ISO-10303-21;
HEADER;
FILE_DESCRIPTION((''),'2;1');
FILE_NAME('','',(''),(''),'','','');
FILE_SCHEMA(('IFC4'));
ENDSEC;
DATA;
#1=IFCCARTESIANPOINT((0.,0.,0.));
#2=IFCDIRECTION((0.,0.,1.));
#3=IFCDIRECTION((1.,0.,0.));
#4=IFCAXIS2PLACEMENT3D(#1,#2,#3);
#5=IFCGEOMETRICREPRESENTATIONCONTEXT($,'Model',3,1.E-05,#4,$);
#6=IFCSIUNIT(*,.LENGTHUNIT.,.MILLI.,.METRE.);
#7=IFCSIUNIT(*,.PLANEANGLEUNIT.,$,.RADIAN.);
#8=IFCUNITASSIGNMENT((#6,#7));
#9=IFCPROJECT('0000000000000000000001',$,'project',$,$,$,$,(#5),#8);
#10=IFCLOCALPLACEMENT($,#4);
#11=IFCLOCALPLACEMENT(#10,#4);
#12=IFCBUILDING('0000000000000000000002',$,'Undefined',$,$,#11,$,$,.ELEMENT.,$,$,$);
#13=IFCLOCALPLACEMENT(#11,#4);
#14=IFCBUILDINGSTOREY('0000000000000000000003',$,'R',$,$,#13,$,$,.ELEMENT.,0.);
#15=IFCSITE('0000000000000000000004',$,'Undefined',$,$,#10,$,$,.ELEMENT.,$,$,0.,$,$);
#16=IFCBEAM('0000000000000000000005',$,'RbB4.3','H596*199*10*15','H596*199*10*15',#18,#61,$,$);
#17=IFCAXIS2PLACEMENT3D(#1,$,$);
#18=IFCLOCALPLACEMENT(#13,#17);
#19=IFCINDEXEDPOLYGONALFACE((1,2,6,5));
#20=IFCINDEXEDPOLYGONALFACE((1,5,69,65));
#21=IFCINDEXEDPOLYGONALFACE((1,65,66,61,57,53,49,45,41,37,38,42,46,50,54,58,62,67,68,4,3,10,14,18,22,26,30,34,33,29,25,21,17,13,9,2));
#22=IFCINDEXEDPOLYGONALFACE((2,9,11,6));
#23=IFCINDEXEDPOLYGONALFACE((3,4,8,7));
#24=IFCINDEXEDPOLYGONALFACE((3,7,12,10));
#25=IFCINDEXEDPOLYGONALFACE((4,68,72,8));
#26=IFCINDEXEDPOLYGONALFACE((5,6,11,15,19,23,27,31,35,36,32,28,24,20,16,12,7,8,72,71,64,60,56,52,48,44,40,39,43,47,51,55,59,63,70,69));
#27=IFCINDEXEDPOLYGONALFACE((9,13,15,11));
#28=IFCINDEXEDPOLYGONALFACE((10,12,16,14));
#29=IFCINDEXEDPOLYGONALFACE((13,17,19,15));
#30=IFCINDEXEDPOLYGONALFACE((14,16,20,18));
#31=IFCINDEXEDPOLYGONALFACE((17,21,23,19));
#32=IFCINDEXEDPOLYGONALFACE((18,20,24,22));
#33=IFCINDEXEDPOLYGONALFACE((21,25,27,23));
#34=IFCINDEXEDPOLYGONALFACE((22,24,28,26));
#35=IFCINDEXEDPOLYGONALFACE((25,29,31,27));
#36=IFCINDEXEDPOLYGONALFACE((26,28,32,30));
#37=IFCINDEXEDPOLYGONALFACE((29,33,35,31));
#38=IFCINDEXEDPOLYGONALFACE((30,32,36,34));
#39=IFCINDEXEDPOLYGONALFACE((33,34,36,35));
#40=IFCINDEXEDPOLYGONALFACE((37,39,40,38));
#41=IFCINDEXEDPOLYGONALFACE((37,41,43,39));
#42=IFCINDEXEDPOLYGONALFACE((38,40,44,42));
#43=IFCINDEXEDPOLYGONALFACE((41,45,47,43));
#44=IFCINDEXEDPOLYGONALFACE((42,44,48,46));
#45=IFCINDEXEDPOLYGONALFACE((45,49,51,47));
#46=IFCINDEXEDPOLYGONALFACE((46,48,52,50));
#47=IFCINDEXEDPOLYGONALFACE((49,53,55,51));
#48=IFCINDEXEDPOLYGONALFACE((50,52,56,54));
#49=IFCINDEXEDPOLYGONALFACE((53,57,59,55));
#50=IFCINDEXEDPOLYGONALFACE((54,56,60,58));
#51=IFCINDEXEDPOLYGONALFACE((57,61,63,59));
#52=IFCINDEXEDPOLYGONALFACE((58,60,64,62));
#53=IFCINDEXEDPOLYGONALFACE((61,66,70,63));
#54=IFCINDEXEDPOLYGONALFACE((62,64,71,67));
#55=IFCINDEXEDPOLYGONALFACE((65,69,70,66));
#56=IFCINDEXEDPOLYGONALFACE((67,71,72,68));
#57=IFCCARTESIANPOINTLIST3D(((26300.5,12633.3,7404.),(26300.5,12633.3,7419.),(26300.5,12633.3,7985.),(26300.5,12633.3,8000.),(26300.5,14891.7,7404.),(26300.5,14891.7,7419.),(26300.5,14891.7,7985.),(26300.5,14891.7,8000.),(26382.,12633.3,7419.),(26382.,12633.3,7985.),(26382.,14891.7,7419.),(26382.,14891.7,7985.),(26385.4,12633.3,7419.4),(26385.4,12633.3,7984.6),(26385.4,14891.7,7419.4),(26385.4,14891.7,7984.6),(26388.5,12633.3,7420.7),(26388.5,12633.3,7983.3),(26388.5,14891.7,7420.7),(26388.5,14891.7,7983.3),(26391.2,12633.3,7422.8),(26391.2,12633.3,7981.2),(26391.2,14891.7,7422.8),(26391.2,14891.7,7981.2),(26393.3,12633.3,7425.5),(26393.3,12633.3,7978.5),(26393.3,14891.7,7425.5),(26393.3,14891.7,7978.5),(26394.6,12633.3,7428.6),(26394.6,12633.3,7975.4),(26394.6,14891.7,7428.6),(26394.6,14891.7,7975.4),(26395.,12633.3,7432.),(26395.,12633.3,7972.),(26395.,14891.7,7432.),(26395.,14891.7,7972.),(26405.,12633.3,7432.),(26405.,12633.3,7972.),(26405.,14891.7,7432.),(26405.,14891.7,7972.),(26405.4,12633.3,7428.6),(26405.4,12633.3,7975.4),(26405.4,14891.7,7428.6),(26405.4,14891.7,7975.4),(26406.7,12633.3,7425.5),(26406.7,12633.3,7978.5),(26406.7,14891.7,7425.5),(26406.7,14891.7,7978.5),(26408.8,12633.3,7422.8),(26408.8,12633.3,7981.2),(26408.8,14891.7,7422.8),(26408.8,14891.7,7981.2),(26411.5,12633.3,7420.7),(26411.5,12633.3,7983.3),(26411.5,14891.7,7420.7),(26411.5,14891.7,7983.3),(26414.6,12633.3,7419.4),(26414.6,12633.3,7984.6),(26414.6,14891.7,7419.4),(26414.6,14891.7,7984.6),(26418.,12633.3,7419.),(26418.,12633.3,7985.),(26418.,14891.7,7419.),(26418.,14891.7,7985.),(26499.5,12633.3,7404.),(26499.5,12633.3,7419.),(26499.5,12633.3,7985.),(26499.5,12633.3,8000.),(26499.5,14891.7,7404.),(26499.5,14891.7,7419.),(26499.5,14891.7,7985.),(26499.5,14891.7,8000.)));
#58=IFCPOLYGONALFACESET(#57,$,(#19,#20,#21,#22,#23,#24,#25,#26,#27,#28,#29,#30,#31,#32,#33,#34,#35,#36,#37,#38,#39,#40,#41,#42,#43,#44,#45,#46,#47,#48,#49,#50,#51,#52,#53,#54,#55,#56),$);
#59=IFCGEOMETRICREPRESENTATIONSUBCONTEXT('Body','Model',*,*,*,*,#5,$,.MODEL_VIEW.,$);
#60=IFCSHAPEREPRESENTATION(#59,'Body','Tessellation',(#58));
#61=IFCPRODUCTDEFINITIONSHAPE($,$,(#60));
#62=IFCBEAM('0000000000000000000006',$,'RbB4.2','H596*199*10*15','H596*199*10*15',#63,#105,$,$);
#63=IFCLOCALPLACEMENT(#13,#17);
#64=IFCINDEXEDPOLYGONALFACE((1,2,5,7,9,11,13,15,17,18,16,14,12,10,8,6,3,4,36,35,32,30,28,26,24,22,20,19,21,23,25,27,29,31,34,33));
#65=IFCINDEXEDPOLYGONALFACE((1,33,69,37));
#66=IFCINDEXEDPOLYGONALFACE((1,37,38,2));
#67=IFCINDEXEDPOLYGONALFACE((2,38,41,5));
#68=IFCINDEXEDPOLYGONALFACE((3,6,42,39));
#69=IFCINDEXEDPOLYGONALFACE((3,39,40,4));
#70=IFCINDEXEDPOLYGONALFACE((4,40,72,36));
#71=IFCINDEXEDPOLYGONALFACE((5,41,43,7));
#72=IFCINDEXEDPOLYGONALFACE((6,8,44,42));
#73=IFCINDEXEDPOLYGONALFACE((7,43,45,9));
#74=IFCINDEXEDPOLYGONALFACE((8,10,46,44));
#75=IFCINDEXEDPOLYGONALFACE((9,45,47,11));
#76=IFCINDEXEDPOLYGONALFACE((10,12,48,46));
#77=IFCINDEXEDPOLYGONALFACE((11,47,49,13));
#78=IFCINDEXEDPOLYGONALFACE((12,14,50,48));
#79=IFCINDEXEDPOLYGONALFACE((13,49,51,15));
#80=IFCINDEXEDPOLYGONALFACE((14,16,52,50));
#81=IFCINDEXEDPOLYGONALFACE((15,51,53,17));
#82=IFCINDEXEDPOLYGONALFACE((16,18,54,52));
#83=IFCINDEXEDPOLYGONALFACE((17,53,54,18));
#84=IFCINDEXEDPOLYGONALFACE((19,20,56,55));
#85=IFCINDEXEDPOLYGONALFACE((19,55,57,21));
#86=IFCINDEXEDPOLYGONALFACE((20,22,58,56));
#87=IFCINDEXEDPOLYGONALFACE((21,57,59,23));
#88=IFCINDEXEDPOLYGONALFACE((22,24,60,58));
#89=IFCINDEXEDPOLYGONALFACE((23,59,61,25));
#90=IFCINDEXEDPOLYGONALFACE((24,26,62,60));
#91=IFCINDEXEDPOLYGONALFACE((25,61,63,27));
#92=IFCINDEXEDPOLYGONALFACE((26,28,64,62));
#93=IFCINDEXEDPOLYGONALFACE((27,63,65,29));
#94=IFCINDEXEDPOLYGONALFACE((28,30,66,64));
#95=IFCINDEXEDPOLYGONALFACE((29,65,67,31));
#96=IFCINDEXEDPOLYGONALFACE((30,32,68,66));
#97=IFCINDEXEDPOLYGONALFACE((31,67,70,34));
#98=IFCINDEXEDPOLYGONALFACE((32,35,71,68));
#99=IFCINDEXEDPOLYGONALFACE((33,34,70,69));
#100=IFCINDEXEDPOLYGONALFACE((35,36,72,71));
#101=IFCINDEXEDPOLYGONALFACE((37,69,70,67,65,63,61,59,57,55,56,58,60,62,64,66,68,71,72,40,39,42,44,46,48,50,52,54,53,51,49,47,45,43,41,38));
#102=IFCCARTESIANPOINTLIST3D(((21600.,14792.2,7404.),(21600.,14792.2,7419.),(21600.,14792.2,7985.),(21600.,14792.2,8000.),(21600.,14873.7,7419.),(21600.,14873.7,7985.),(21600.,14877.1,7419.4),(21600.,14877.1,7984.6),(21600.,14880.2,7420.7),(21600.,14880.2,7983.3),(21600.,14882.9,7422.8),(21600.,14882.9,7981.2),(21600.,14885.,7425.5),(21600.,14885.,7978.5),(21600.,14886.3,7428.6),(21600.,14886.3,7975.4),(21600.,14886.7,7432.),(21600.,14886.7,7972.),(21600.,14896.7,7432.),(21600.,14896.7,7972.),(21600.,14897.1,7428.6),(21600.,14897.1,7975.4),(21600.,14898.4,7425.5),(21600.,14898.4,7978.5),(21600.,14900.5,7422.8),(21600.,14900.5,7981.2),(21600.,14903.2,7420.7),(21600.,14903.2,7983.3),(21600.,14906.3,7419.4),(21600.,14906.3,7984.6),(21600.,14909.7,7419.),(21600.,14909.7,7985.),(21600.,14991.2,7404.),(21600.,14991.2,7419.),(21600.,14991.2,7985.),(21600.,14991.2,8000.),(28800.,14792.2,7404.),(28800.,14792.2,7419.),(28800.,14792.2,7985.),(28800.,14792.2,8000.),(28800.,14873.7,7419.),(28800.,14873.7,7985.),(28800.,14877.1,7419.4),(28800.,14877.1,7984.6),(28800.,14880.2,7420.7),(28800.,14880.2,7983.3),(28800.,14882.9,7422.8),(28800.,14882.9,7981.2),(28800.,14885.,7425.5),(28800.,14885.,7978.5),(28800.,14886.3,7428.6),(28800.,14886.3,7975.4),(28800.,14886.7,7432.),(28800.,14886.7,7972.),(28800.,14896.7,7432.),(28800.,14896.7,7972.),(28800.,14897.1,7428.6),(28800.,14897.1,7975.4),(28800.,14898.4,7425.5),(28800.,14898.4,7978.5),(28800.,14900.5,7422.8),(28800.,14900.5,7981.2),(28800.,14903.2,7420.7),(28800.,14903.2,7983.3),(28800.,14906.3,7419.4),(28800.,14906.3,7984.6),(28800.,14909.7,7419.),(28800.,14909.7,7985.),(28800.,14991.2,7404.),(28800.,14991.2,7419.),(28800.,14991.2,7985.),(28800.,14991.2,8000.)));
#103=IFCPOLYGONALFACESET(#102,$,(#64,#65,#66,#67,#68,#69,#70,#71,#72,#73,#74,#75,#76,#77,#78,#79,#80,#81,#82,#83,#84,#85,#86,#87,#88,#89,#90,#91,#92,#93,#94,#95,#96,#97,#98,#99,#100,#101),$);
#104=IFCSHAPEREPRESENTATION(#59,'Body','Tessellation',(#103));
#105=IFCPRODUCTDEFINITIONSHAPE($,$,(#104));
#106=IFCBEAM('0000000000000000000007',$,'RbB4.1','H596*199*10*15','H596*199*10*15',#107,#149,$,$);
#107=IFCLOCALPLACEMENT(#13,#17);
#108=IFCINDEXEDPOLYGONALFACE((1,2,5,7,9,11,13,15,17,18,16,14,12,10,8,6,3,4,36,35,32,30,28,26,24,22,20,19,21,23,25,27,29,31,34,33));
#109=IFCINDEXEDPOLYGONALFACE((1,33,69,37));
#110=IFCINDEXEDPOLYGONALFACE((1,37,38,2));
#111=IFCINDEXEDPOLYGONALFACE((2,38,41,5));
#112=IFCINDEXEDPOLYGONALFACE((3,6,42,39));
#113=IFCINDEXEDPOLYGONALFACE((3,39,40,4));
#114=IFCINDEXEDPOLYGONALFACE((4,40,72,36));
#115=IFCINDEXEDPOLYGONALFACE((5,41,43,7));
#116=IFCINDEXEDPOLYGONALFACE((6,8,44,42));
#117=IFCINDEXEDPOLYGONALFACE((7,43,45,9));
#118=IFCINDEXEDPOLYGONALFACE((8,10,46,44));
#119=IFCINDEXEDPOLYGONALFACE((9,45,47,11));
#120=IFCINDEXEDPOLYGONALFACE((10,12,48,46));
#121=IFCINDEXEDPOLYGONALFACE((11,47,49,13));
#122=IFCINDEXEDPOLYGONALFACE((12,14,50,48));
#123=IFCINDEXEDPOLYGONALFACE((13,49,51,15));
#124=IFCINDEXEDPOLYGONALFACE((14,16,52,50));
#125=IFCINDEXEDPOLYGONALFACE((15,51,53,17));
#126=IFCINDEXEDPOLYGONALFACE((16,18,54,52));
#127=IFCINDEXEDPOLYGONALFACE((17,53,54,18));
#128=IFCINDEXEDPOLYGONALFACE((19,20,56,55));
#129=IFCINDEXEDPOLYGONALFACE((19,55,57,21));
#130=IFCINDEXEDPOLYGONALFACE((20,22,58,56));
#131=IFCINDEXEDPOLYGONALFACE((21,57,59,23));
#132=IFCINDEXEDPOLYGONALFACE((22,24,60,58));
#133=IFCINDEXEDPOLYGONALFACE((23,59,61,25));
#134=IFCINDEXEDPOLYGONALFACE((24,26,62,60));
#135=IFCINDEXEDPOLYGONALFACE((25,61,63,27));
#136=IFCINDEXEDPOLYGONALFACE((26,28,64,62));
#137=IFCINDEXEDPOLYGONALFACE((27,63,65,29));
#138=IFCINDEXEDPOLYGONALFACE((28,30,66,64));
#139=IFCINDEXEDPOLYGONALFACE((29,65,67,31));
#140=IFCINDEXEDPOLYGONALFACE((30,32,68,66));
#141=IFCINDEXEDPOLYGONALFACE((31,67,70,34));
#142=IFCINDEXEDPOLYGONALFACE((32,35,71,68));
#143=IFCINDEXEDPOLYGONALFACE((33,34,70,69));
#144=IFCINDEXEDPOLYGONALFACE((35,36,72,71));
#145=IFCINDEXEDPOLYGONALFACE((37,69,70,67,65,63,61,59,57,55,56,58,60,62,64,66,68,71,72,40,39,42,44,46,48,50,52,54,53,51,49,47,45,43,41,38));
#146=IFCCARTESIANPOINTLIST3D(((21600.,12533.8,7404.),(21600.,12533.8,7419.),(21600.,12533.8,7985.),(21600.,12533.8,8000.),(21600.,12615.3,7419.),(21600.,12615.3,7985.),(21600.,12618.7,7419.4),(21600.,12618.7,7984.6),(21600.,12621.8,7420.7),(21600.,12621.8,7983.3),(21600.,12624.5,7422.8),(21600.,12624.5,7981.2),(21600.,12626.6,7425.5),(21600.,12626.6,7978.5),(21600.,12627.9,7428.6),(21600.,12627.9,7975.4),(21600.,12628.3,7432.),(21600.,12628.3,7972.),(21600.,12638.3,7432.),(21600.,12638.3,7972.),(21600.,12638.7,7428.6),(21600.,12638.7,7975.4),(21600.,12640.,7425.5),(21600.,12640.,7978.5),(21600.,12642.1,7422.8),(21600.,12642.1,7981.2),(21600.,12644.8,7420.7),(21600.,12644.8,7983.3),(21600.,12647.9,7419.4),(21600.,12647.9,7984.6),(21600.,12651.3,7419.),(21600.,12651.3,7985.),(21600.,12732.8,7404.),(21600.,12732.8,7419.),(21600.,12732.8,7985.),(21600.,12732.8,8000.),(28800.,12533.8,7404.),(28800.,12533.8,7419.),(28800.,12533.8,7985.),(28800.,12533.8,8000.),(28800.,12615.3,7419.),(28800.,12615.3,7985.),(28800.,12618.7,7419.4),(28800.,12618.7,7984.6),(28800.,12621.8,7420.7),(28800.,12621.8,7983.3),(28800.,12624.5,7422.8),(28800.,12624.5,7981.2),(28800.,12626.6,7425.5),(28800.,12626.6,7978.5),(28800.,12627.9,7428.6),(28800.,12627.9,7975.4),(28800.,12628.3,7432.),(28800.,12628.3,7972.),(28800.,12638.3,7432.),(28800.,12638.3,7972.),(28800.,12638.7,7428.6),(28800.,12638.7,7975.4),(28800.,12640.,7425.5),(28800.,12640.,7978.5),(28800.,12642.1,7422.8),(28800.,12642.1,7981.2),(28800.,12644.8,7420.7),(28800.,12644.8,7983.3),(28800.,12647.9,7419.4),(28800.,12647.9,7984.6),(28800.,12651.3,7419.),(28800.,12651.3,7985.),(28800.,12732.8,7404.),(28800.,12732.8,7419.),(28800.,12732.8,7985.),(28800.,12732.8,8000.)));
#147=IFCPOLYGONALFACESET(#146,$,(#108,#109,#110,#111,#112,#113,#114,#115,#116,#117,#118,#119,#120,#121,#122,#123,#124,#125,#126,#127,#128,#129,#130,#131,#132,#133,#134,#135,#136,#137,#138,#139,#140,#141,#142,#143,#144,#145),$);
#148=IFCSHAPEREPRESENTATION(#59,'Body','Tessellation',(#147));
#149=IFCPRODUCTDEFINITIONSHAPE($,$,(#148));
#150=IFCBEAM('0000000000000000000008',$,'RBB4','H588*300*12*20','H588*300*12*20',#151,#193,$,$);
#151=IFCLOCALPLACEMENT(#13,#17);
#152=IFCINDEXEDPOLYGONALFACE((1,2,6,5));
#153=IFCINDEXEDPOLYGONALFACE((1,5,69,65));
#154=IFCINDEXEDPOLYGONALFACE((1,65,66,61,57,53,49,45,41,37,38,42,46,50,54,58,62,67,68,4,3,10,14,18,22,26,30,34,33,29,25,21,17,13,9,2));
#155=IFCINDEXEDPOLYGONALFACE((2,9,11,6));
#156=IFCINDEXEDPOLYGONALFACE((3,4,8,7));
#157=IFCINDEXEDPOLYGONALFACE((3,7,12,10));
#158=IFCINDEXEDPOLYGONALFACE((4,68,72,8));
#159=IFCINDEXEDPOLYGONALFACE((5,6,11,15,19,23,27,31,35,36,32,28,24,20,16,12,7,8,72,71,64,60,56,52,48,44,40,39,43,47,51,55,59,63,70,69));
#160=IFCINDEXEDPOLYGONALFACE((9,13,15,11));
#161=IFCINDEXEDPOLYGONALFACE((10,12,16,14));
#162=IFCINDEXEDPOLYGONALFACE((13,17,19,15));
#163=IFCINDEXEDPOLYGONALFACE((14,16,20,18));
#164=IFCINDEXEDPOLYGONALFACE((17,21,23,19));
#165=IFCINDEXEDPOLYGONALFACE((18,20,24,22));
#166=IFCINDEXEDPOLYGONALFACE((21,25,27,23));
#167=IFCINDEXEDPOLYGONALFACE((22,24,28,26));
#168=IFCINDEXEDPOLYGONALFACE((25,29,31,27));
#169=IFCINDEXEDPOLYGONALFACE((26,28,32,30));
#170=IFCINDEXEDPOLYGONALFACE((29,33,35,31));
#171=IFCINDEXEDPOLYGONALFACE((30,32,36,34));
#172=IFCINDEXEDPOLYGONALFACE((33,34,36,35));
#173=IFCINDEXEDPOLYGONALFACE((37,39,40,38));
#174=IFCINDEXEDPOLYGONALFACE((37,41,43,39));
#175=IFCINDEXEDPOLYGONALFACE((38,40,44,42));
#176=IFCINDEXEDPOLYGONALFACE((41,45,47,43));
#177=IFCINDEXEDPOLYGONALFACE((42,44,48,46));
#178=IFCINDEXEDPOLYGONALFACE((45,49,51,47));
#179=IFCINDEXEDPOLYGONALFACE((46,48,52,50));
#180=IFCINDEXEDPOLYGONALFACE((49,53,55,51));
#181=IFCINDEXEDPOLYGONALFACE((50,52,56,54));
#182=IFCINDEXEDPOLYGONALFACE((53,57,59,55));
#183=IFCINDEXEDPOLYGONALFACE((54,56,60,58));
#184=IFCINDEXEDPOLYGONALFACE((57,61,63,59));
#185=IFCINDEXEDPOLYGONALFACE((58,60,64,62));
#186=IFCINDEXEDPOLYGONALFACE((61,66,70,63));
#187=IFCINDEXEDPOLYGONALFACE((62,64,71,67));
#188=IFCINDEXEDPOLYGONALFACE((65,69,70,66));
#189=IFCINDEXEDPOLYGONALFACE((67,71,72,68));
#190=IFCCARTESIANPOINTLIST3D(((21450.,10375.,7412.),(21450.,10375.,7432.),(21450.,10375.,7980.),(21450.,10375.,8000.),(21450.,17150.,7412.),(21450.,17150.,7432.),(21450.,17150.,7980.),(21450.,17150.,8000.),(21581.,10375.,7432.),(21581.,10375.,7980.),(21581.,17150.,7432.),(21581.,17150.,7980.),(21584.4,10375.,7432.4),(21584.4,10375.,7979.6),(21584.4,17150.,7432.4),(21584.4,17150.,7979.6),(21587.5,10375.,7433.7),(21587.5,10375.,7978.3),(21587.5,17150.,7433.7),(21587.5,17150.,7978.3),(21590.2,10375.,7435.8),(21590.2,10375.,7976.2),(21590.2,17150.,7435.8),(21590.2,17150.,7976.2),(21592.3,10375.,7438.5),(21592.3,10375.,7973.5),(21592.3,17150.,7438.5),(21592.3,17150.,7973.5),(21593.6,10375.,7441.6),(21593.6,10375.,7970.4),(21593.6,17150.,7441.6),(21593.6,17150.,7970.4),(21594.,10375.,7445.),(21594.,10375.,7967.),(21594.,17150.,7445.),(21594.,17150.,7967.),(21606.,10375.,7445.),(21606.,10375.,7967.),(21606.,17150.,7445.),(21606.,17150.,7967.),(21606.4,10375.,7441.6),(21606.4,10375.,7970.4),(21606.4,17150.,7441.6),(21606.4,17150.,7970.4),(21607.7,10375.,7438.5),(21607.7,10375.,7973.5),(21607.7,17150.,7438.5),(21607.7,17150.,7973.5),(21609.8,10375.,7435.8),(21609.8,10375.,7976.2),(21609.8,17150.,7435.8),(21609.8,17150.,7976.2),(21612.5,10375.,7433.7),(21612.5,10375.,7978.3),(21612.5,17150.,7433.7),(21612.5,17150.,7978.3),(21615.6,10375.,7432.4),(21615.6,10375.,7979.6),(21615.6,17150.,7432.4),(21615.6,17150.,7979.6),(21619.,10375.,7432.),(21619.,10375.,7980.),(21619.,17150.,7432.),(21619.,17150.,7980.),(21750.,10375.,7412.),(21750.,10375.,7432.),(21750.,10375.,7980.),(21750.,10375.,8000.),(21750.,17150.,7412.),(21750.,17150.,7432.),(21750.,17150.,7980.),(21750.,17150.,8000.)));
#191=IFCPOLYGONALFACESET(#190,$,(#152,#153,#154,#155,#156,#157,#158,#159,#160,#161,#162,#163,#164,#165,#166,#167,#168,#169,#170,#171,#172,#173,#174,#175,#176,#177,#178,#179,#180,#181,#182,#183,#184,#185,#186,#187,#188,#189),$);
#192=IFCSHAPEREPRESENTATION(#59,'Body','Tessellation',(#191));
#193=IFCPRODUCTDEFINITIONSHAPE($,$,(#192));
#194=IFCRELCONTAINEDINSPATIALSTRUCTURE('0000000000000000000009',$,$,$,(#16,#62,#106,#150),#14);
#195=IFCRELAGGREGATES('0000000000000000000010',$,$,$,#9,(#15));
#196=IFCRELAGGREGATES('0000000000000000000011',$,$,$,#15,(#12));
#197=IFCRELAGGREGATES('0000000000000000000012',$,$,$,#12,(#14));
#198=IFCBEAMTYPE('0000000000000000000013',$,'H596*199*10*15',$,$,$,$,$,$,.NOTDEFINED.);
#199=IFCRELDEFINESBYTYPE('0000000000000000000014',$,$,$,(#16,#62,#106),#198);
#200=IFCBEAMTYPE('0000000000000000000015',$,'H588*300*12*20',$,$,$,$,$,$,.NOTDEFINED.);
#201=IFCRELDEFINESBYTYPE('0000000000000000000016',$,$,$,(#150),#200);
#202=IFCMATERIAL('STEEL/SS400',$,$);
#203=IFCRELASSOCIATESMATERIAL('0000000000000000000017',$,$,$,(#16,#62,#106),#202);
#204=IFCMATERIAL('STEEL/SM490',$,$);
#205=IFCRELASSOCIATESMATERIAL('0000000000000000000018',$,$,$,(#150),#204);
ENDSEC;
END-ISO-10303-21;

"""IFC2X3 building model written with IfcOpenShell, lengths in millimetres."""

from ifc_helpers import new_model, si_unit, frame, origin_with_axes, origin_2d_with_axis, place, context, subcontext, project, spatial, i_section, extrude, material, type_object, element, save


model = new_model("IFC2X3")

# Units and contexts
model_context = context("Model", 3, precision=1e-05, world=origin_with_axes())
body_context = subcontext(model_context, "Body", "Model", "MODEL_VIEW")
ifc_project = project(units=[si_unit("LENGTHUNIT", "METRE", prefix="MILLI"), si_unit("PLANEANGLEUNIT", "RADIAN")], contexts=[model_context])

# Site, building, storey
site_placement = place(None, origin_with_axes())
site = spatial("IfcSite", under=ifc_project, at=site_placement, Name="Undefined", CompositionType="ELEMENT", RefElevation=0.0)
building_placement = place(site_placement, origin_with_axes())
building = spatial("IfcBuilding", under=site, at=building_placement, Name="Undefined", CompositionType="ELEMENT")
storey_placement = place(building_placement, origin_with_axes())
storey = spatial("IfcBuildingStorey", under=building, at=storey_placement, Name="R", CompositionType="ELEMENT", Elevation=0.0)

# Beams
ifc_material_1 = material(Name="STEEL/SS400")
beam_type_1 = type_object("IfcBeamType", Name="H596*199*10*15", PredefinedType="NOTDEFINED")
beam_1_placement = place(storey_placement, frame((26400.0, 12633.3, 7702.0), z_axis=(0.0, 0.0, 1.0), x_axis=(0.0, 1.0, 0.0)))
element("IfcBeam", 1, at=beam_1_placement, inside=storey, type_object=beam_type_1, material=ifc_material_1, Name="RbB4.3", Description="H596*199*10*15", ObjectType="H596*199*10*15", context=body_context, shape_type="SweptSolid", body=[
    extrude(i_section(OverallWidth=199.0, OverallDepth=596.0, WebThickness=10.0, FlangeThickness=15.0, FilletRadius=13.0, at=origin_2d_with_axis()), frame((2258.4, 0.0, 0.0), z_axis=(-1.0, 0.0, 0.0), x_axis=(0.0, -1.0, 0.0)), (0.0, 0.0, 1.0), 2258.4),
])
for number, where, z_axis, x_axis, name in (
    (2, (21600.0, 14891.7, 7702.0), (0.0, 0.0, 1.0), (1.0, 0.0, 0.0), "RbB4.2"),
    (3, (21600.0, 12633.3, 7702.0), (0.0, 0.0, 1.0), (1.0, 0.0, 0.0), "RbB4.1"),
):
    element("IfcBeam", number, at=place(storey_placement, frame(where, z_axis=z_axis, x_axis=x_axis)), inside=storey, type_object=beam_type_1, material=ifc_material_1, Name=name, Description="H596*199*10*15", ObjectType="H596*199*10*15", context=body_context, shape_type="SweptSolid", body=[
        extrude(i_section(OverallWidth=199.0, OverallDepth=596.0, WebThickness=10.0, FlangeThickness=15.0, FilletRadius=13.0, at=origin_2d_with_axis()), frame((7200.0, 0.0, 0.0), z_axis=(-1.0, 0.0, 0.0), x_axis=(0.0, -1.0, 0.0)), (0.0, 0.0, 1.0), 7200.0),
    ])
ifc_material_2 = material(Name="STEEL/SM490")
beam_type_2 = type_object("IfcBeamType", Name="H588*300*12*20", PredefinedType="NOTDEFINED")
beam_2_placement = place(storey_placement, frame((21600.0, 10375.0, 7706.0), z_axis=(0.0, 0.0, 1.0), x_axis=(0.0, 1.0, 0.0)))
element("IfcBeam", 4, at=beam_2_placement, inside=storey, type_object=beam_type_2, material=ifc_material_2, Name="RBB4", Description="H588*300*12*20", ObjectType="H588*300*12*20", context=body_context, shape_type="SweptSolid", body=[
    extrude(i_section(OverallWidth=300.0, OverallDepth=588.0, WebThickness=12.0, FlangeThickness=20.0, FilletRadius=13.0, at=origin_2d_with_axis()), frame((6775.0, 0.0, 0.0), z_axis=(-1.0, 0.0, 0.0), x_axis=(0.0, -1.0, 0.0)), (0.0, 0.0, 1.0), 6775.0),
])

save(model, "model.ifc")
